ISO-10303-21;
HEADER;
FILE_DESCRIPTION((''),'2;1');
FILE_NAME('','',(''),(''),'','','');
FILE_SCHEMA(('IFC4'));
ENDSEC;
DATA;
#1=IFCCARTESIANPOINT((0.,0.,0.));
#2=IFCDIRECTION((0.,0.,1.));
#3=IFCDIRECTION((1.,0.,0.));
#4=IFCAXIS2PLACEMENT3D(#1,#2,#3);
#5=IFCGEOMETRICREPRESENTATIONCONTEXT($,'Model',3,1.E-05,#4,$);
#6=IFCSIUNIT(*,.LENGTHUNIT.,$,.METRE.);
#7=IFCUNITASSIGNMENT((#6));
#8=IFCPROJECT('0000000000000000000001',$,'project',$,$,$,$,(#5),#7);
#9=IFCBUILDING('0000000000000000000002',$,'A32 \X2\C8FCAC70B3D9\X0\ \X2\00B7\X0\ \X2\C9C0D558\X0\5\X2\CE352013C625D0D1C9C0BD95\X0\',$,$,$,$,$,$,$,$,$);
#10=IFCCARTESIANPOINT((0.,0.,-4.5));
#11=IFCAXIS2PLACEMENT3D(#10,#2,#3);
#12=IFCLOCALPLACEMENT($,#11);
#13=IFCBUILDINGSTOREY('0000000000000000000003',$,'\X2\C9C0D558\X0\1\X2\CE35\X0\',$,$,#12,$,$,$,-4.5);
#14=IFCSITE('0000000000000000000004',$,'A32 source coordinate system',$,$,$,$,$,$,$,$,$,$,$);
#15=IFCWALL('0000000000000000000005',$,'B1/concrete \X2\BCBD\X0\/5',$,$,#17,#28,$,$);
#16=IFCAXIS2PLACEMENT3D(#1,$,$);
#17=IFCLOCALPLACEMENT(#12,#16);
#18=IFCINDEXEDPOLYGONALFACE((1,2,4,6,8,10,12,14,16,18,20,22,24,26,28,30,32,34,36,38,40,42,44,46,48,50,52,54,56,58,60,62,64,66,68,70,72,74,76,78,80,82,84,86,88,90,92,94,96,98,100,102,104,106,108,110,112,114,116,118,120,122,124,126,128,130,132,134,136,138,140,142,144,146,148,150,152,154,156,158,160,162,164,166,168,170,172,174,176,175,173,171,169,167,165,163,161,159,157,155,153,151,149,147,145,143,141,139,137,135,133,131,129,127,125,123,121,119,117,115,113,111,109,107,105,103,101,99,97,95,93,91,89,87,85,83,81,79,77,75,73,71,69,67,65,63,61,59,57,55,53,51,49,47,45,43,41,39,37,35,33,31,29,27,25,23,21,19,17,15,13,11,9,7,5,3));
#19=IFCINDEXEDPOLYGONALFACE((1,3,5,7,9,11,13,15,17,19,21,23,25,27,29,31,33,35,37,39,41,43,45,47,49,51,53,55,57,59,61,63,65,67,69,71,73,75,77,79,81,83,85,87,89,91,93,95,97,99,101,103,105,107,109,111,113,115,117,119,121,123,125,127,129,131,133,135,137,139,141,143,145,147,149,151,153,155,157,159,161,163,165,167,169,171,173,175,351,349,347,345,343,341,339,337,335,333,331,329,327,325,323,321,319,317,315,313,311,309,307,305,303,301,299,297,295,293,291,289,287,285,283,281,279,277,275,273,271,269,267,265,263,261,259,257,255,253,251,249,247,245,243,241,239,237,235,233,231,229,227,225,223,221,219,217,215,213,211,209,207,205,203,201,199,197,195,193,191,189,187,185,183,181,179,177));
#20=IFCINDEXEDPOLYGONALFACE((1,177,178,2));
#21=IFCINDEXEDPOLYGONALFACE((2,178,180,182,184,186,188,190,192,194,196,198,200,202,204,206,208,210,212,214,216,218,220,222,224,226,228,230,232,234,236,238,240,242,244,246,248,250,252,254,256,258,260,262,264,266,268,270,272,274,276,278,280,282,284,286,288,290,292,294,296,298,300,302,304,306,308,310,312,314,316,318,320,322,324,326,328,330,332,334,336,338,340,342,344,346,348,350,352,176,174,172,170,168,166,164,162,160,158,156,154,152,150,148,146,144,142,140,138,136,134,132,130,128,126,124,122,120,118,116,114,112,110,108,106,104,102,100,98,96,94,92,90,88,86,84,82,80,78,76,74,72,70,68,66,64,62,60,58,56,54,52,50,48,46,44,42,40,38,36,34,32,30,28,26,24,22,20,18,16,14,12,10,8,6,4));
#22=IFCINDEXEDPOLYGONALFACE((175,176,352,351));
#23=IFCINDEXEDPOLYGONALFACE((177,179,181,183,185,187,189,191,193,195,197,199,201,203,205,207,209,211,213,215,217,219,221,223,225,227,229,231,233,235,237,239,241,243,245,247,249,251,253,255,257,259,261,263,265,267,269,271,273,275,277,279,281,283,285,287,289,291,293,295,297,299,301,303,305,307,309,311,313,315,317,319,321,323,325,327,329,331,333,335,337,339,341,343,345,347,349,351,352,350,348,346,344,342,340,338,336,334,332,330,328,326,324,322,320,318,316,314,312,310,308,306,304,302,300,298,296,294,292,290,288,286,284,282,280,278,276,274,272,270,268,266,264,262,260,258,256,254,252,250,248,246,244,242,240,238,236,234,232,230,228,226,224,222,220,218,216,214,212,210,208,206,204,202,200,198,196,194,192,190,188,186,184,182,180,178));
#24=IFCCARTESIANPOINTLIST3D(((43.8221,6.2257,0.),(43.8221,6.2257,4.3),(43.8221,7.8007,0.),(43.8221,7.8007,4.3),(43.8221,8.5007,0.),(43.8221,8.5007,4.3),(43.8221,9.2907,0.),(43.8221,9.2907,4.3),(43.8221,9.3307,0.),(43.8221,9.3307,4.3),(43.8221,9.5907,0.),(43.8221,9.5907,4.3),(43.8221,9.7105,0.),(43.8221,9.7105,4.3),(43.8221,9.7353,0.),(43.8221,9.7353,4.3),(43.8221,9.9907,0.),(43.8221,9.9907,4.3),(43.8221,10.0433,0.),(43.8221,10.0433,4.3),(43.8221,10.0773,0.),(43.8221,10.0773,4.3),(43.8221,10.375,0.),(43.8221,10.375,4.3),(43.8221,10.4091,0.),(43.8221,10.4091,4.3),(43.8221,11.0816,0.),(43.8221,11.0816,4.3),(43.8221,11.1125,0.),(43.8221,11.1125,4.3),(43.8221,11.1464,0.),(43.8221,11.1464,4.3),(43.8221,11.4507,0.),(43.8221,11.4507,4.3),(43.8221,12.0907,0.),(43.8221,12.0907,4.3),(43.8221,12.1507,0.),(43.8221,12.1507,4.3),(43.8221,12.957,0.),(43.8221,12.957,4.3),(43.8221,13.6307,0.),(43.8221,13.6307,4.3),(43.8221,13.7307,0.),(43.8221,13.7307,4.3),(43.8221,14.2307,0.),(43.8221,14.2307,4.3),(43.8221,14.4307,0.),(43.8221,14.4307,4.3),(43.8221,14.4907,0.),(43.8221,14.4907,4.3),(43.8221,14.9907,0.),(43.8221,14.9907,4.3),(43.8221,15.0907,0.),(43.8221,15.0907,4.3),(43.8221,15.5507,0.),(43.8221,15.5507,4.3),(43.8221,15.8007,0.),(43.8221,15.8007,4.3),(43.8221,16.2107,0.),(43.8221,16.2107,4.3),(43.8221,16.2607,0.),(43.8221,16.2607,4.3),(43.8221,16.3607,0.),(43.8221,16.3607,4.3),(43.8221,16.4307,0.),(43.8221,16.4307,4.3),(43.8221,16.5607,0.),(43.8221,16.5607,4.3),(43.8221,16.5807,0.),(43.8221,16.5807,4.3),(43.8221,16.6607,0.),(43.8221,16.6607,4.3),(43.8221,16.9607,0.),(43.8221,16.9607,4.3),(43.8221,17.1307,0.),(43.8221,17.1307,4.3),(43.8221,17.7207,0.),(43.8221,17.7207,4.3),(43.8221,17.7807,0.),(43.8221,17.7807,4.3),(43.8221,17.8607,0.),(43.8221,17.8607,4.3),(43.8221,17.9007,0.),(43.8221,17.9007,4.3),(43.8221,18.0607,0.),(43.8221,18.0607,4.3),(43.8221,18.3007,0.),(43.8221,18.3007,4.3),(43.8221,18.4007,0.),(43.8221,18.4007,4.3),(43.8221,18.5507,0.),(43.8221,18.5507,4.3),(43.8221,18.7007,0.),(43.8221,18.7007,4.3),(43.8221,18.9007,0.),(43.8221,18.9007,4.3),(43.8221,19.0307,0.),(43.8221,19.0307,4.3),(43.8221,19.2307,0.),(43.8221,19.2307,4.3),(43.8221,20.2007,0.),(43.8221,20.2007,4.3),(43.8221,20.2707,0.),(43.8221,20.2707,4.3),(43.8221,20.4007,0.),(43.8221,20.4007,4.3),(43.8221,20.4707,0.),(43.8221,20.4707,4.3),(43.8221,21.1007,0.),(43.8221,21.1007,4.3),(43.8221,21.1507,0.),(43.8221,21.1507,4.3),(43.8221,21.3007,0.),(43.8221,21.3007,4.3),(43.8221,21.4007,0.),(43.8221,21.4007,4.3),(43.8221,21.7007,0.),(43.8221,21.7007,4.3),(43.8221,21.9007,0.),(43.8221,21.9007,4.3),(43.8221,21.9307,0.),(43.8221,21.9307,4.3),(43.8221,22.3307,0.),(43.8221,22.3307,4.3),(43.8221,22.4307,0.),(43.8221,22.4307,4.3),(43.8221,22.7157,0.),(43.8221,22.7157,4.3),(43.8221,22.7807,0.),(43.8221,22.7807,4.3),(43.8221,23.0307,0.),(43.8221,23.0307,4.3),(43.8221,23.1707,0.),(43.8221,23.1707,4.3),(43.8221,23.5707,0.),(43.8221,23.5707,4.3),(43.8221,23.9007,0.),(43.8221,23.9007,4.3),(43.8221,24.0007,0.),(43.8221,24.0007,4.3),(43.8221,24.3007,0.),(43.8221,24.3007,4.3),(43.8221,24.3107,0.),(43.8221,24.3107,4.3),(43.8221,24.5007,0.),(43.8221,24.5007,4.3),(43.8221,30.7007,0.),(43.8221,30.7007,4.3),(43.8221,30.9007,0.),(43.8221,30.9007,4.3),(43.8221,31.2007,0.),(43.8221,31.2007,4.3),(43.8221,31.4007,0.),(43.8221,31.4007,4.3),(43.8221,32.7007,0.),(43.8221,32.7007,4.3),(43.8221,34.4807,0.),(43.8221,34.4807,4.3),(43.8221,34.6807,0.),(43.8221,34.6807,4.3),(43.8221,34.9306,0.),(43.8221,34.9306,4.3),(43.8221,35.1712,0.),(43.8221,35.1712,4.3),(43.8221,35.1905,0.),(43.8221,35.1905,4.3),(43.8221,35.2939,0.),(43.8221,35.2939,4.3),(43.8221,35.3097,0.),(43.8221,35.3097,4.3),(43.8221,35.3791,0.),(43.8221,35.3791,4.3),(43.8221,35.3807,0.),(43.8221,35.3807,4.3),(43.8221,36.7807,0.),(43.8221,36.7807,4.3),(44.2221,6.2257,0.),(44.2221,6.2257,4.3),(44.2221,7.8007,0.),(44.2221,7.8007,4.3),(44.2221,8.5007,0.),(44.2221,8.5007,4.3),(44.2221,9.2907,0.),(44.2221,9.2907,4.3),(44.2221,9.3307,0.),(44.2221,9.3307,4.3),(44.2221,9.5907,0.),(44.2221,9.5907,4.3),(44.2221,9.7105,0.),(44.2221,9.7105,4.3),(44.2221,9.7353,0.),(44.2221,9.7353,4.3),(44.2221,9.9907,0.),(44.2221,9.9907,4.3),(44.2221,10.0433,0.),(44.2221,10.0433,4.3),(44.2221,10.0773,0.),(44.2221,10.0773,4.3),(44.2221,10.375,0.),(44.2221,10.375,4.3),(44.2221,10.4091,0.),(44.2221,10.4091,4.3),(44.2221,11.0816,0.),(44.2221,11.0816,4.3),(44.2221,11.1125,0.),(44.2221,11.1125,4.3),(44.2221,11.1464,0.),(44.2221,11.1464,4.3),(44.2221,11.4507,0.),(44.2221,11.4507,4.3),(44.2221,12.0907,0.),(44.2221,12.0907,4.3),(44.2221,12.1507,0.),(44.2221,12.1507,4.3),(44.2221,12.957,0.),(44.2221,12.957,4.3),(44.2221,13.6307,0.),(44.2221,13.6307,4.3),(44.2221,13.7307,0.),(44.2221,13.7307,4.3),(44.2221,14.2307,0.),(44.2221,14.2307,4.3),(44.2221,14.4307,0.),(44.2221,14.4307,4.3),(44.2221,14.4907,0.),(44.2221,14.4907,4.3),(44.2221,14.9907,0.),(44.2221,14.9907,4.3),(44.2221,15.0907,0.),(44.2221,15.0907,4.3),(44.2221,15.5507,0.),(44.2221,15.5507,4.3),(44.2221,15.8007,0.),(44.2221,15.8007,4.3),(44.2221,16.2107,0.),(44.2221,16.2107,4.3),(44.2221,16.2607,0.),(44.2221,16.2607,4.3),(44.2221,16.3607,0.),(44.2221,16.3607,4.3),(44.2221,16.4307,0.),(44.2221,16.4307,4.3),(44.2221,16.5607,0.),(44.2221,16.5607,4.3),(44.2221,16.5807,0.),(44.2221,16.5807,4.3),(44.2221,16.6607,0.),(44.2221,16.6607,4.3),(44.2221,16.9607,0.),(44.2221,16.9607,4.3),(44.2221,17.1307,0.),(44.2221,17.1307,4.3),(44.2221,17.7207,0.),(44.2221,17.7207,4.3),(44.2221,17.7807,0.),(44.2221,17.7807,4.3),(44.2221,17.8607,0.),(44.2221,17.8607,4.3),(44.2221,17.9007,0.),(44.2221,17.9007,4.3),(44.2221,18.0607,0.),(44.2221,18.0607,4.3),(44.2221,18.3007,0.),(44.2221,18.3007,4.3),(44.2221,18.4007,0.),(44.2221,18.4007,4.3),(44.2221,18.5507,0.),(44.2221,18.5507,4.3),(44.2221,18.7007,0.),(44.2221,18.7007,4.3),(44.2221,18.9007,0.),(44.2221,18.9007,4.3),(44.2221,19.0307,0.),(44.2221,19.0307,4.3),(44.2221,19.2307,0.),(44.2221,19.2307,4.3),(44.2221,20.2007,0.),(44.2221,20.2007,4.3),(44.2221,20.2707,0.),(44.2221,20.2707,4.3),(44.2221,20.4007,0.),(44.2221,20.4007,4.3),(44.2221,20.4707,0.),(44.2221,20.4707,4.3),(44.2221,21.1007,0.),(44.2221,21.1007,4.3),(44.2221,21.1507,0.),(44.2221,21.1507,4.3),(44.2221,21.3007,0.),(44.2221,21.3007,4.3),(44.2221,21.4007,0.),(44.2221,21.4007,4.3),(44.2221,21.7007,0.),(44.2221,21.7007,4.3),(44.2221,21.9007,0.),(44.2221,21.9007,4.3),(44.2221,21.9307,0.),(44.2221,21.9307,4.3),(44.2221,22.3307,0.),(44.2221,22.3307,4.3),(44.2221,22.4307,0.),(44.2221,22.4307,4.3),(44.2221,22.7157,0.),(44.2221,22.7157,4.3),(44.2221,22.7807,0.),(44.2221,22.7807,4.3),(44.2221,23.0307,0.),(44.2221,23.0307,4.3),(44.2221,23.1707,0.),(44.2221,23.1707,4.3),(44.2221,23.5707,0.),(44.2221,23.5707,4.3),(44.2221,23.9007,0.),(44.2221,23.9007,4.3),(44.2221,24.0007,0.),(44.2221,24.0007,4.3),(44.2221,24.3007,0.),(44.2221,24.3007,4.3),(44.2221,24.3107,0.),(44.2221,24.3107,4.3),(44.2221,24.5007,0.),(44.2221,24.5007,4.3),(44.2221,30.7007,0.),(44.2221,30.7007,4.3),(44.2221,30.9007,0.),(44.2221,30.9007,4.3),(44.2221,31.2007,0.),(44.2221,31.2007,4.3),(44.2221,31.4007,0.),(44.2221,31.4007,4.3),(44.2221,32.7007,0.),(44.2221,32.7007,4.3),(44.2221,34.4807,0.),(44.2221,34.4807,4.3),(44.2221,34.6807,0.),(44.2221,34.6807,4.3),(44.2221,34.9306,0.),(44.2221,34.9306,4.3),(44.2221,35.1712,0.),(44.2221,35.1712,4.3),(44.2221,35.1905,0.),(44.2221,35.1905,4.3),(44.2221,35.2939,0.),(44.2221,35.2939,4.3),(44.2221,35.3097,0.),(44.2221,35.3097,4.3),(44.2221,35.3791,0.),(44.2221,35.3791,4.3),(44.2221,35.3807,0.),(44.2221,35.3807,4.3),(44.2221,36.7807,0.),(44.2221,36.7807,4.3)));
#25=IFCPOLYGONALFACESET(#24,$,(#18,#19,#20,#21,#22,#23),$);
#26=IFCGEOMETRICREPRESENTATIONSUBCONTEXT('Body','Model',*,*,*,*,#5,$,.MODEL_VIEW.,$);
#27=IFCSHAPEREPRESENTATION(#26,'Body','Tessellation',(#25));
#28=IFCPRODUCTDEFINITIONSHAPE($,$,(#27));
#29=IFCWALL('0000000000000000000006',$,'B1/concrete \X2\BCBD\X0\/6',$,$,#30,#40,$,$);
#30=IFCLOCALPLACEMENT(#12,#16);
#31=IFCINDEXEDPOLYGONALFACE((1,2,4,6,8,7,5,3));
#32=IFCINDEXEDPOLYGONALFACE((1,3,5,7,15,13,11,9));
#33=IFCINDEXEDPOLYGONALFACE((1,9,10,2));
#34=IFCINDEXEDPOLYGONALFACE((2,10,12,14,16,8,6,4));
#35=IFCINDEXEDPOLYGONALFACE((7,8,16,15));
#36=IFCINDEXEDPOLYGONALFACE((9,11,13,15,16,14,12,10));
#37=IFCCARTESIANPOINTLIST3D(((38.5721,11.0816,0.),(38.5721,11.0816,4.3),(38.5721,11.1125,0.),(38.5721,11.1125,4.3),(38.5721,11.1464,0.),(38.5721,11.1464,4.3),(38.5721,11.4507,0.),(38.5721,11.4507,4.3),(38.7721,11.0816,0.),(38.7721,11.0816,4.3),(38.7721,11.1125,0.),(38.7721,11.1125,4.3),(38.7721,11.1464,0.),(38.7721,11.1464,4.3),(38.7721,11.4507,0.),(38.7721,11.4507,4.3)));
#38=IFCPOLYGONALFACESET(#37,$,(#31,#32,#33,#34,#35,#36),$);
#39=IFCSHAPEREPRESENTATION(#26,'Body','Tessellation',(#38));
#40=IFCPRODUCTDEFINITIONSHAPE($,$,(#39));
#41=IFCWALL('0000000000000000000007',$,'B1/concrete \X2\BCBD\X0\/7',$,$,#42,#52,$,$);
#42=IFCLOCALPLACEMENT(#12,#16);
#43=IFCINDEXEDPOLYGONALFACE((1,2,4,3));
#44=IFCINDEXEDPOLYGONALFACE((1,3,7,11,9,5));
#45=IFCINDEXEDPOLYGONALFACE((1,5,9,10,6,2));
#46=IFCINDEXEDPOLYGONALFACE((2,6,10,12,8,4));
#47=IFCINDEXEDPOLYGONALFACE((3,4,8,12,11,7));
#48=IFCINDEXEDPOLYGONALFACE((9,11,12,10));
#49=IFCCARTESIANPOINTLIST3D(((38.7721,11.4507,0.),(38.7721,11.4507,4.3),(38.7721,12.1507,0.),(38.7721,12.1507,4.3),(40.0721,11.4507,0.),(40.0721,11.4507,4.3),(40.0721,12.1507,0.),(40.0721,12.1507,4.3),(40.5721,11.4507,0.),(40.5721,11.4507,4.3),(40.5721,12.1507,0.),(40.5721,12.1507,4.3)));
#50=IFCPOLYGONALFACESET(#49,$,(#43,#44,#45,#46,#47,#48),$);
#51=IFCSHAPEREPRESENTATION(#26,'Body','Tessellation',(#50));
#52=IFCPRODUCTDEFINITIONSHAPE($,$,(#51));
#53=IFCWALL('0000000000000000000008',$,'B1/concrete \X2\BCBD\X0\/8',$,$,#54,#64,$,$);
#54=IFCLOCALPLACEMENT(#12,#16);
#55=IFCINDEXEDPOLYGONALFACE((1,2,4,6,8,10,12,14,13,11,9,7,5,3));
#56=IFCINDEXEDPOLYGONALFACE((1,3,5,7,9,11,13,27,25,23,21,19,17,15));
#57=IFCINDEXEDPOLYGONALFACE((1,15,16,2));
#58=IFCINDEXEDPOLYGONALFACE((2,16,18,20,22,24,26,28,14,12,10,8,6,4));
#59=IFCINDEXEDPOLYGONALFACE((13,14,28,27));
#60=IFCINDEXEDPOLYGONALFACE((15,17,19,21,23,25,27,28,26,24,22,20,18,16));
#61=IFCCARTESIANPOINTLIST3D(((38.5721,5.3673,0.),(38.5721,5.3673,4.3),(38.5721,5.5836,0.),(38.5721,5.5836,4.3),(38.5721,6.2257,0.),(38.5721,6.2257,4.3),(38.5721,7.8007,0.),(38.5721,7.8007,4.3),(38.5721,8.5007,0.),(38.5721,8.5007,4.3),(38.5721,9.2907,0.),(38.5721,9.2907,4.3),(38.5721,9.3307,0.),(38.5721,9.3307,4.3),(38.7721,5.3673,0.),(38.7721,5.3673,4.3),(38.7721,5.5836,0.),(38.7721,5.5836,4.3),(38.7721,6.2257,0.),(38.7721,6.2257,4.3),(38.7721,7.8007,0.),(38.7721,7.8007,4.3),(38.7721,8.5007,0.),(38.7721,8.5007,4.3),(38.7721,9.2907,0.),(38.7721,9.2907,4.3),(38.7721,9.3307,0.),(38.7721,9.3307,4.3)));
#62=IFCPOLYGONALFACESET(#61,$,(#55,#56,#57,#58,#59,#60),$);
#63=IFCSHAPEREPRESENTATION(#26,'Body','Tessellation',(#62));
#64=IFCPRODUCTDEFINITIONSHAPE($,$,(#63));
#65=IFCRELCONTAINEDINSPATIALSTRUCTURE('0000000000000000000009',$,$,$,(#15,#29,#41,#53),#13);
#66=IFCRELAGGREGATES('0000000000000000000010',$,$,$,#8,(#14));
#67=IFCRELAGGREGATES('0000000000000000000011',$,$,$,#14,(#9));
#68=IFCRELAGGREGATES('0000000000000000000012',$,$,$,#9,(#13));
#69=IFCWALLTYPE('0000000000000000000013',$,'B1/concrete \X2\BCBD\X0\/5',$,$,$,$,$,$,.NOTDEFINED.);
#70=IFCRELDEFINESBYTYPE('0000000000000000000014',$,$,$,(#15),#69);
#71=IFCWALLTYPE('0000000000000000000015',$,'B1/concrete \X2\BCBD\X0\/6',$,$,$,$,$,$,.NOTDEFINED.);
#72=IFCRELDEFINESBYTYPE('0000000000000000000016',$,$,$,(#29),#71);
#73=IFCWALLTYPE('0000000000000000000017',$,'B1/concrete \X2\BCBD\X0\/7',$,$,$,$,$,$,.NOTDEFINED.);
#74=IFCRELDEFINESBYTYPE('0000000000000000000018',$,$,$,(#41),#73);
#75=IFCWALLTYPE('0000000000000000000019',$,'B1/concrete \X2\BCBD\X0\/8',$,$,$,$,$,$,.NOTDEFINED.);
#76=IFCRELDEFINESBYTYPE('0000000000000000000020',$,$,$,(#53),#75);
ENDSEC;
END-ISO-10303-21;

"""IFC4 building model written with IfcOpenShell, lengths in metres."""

from ifc_helpers import new_model, si_unit, frame, origin, origin_with_axes, place, context, subcontext, project, spatial, polyline, outline, extrude, source, transform, mapped, type_object, type_shapes, element, save


model = new_model("IFC4")

# Units and contexts
model_context = context("Model", 3, precision=1e-05, world=origin_with_axes())
body_context = subcontext(model_context, "Body", "Model", "MODEL_VIEW")
ifc_project = project(units=[si_unit("LENGTHUNIT", "METRE")], contexts=[model_context])

# Site, building, storey
site = spatial("IfcSite", under=ifc_project, Name="A32 source coordinate system")
building = spatial("IfcBuilding", under=site, Name="A32 주거동 · 지하5층–옥탑지붕")
storey_placement = place(None, frame((0.0, 0.0, -4.5), z_axis=(0.0, 0.0, 1.0), x_axis=(1.0, 0.0, 0.0)))
storey = spatial("IfcBuildingStorey", under=building, at=storey_placement, Name="지하1층", Elevation=-4.5)

# Walls
wall_type_1 = type_object("IfcWallType", Name="B1/concrete 벽/5", PredefinedType="NOTDEFINED")
shared_shape_1 = source(origin(), body_context, "Body", "SweptSolid", [
    extrude(outline(polyline([(44.2221, 35.3791), (44.2221, 35.3097), (44.2221, 35.2939), (44.2221, 35.1905), (44.2221, 35.1712), (44.2221, 34.9306), (44.2221, 34.6807), (44.2221, 34.4807), (44.2221, 32.7007), (44.2221, 31.4007), (44.2221, 31.2007), (44.2221, 30.9007), (44.2221, 30.7007), (44.2221, 24.5007), (44.2221, 24.3107), (44.2221, 24.3007), (44.2221, 24.0007), (44.2221, 23.9007), (44.2221, 23.5707), (44.2221, 23.1707), (44.2221, 23.0307), (44.2221, 22.7807), (44.2221, 22.7157), (44.2221, 22.4307), (44.2221, 22.3307), (44.2221, 21.9307), (44.2221, 21.9007), (44.2221, 21.7007), (44.2221, 21.4007), (44.2221, 21.3007), (44.2221, 21.1507), (44.2221, 21.1007), (44.2221, 20.4707), (44.2221, 20.4007), (44.2221, 20.2707), (44.2221, 20.2007), (44.2221, 19.2307), (44.2221, 19.0307), (44.2221, 18.9007), (44.2221, 18.7007), (44.2221, 18.5507), (44.2221, 18.4007), (44.2221, 18.3007), (44.2221, 18.0607), (44.2221, 17.9007), (44.2221, 17.8607), (44.2221, 17.7807), (44.2221, 17.7207), (44.2221, 17.1307), (44.2221, 16.9607), (44.2221, 16.6607), (44.2221, 16.5807), (44.2221, 16.5607), (44.2221, 16.4307), (44.2221, 16.3607), (44.2221, 16.2607), (44.2221, 16.2107), (44.2221, 15.8007), (44.2221, 15.5507), (44.2221, 15.0907), (44.2221, 14.9907), (44.2221, 14.4907), (44.2221, 14.4307), (44.2221, 14.2307), (44.2221, 13.7307), (44.2221, 13.6307), (44.2221, 12.957), (44.2221, 12.1507), (44.2221, 12.0907), (44.2221, 11.4507), (44.2221, 11.1464), (44.2221, 11.1125), (44.2221, 11.0816), (44.2221, 10.4091), (44.2221, 10.375), (44.2221, 10.0773), (44.2221, 10.0433), (44.2221, 9.9907), (44.2221, 9.7353), (44.2221, 9.7105), (44.2221, 9.5907), (44.2221, 9.3307), (44.2221, 9.2907), (44.2221, 8.5007), (44.2221, 7.8007), (44.2221, 6.2257), (43.8221, 6.2257), (43.8221, 7.8007), (43.8221, 8.5007), (43.8221, 9.2907), (43.8221, 9.3307), (43.8221, 9.5907), (43.8221, 9.7105), (43.8221, 9.7353), (43.8221, 9.9907), (43.8221, 10.0433), (43.8221, 10.0773), (43.8221, 10.375), (43.8221, 10.4091), (43.8221, 11.0816), (43.8221, 11.1125), (43.8221, 11.1464), (43.8221, 11.4507), (43.8221, 12.0907), (43.8221, 12.1507), (43.8221, 12.957), (43.8221, 13.6307), (43.8221, 13.7307), (43.8221, 14.2307), (43.8221, 14.4307), (43.8221, 14.4907), (43.8221, 14.9907), (43.8221, 15.0907), (43.8221, 15.5507), (43.8221, 15.8007), (43.8221, 16.2107), (43.8221, 16.2607), (43.8221, 16.3607), (43.8221, 16.4307), (43.8221, 16.5607), (43.8221, 16.5807), (43.8221, 16.6607), (43.8221, 16.9607), (43.8221, 17.1307), (43.8221, 17.7207), (43.8221, 17.7807), (43.8221, 17.8607), (43.8221, 17.9007), (43.8221, 18.0607), (43.8221, 18.3007), (43.8221, 18.4007), (43.8221, 18.5507), (43.8221, 18.7007), (43.8221, 18.9007), (43.8221, 19.0307), (43.8221, 19.2307), (43.8221, 20.2007), (43.8221, 20.2707), (43.8221, 20.4007), (43.8221, 20.4707), (43.8221, 21.1007), (43.8221, 21.1507), (43.8221, 21.3007), (43.8221, 21.4007), (43.8221, 21.7007), (43.8221, 21.9007), (43.8221, 21.9307), (43.8221, 22.3307), (43.8221, 22.4307), (43.8221, 22.7157), (43.8221, 22.7807), (43.8221, 23.0307), (43.8221, 23.1707), (43.8221, 23.5707), (43.8221, 23.9007), (43.8221, 24.0007), (43.8221, 24.3007), (43.8221, 24.3107), (43.8221, 24.5007), (43.8221, 30.7007), (43.8221, 30.9007), (43.8221, 31.2007), (43.8221, 31.4007), (43.8221, 32.7007), (43.8221, 34.4807), (43.8221, 34.6807), (43.8221, 34.9306), (43.8221, 35.1712), (43.8221, 35.1905), (43.8221, 35.2939), (43.8221, 35.3097), (43.8221, 35.3791), (43.8221, 35.3807), (43.8221, 36.7807), (44.2221, 36.7807), (44.2221, 35.3807), (44.2221, 35.3791)])), origin(), (0.0, 0.0, 1.0), 4.3),
])
type_shapes(wall_type_1, [shared_shape_1])
wall_1_placement = place(storey_placement, origin_with_axes())
element("IfcWall", 1, at=wall_1_placement, inside=storey, type_object=wall_type_1, Name="B1/concrete 벽/5", context=body_context, shape_type="MappedRepresentation", body=[
    mapped(shared_shape_1, transform((0.0, 0.0, 0.0), scale=1.0)),
])
wall_type_2 = type_object("IfcWallType", Name="B1/concrete 벽/6", PredefinedType="NOTDEFINED")
shared_shape_2 = source(origin(), body_context, "Body", "SweptSolid", [
    extrude(outline(polyline([(38.7721, 11.1464), (38.7721, 11.1125), (38.7721, 11.0816), (38.5721, 11.0816), (38.5721, 11.1125), (38.5721, 11.1464), (38.5721, 11.4507), (38.7721, 11.4507), (38.7721, 11.1464)])), origin(), (0.0, 0.0, 1.0), 4.3),
])
type_shapes(wall_type_2, [shared_shape_2])
wall_2_placement = place(storey_placement, origin_with_axes())
element("IfcWall", 2, at=wall_2_placement, inside=storey, type_object=wall_type_2, Name="B1/concrete 벽/6", context=body_context, shape_type="MappedRepresentation", body=[
    mapped(shared_shape_2, transform((0.0, 0.0, 0.0), scale=1.0)),
])
wall_type_3 = type_object("IfcWallType", Name="B1/concrete 벽/7", PredefinedType="NOTDEFINED")
shared_shape_3 = source(origin(), body_context, "Body", "SweptSolid", [
    extrude(outline(polyline([(40.5721, 12.1507), (40.5721, 11.4507), (40.0721, 11.4507), (38.7721, 11.4507), (38.7721, 12.1507), (40.0721, 12.1507), (40.5721, 12.1507)])), origin(), (0.0, 0.0, 1.0), 4.3),
])
type_shapes(wall_type_3, [shared_shape_3])
wall_3_placement = place(storey_placement, origin_with_axes())
element("IfcWall", 3, at=wall_3_placement, inside=storey, type_object=wall_type_3, Name="B1/concrete 벽/7", context=body_context, shape_type="MappedRepresentation", body=[
    mapped(shared_shape_3, transform((0.0, 0.0, 0.0), scale=1.0)),
])
wall_type_4 = type_object("IfcWallType", Name="B1/concrete 벽/8", PredefinedType="NOTDEFINED")
shared_shape_4 = source(origin(), body_context, "Body", "SweptSolid", [
    extrude(outline(polyline([(38.7721, 9.2907), (38.7721, 8.5007), (38.7721, 7.8007), (38.7721, 6.2257), (38.7721, 5.5836), (38.7721, 5.3673), (38.5721, 5.3673), (38.5721, 5.5836), (38.5721, 6.2257), (38.5721, 7.8007), (38.5721, 8.5007), (38.5721, 9.2907), (38.5721, 9.3307), (38.7721, 9.3307), (38.7721, 9.2907)])), origin(), (0.0, 0.0, 1.0), 4.3),
])
type_shapes(wall_type_4, [shared_shape_4])
wall_4_placement = place(storey_placement, origin_with_axes())
element("IfcWall", 4, at=wall_4_placement, inside=storey, type_object=wall_type_4, Name="B1/concrete 벽/8", context=body_context, shape_type="MappedRepresentation", body=[
    mapped(shared_shape_4, transform((0.0, 0.0, 0.0), scale=1.0)),
])

save(model, "model.ifc")
